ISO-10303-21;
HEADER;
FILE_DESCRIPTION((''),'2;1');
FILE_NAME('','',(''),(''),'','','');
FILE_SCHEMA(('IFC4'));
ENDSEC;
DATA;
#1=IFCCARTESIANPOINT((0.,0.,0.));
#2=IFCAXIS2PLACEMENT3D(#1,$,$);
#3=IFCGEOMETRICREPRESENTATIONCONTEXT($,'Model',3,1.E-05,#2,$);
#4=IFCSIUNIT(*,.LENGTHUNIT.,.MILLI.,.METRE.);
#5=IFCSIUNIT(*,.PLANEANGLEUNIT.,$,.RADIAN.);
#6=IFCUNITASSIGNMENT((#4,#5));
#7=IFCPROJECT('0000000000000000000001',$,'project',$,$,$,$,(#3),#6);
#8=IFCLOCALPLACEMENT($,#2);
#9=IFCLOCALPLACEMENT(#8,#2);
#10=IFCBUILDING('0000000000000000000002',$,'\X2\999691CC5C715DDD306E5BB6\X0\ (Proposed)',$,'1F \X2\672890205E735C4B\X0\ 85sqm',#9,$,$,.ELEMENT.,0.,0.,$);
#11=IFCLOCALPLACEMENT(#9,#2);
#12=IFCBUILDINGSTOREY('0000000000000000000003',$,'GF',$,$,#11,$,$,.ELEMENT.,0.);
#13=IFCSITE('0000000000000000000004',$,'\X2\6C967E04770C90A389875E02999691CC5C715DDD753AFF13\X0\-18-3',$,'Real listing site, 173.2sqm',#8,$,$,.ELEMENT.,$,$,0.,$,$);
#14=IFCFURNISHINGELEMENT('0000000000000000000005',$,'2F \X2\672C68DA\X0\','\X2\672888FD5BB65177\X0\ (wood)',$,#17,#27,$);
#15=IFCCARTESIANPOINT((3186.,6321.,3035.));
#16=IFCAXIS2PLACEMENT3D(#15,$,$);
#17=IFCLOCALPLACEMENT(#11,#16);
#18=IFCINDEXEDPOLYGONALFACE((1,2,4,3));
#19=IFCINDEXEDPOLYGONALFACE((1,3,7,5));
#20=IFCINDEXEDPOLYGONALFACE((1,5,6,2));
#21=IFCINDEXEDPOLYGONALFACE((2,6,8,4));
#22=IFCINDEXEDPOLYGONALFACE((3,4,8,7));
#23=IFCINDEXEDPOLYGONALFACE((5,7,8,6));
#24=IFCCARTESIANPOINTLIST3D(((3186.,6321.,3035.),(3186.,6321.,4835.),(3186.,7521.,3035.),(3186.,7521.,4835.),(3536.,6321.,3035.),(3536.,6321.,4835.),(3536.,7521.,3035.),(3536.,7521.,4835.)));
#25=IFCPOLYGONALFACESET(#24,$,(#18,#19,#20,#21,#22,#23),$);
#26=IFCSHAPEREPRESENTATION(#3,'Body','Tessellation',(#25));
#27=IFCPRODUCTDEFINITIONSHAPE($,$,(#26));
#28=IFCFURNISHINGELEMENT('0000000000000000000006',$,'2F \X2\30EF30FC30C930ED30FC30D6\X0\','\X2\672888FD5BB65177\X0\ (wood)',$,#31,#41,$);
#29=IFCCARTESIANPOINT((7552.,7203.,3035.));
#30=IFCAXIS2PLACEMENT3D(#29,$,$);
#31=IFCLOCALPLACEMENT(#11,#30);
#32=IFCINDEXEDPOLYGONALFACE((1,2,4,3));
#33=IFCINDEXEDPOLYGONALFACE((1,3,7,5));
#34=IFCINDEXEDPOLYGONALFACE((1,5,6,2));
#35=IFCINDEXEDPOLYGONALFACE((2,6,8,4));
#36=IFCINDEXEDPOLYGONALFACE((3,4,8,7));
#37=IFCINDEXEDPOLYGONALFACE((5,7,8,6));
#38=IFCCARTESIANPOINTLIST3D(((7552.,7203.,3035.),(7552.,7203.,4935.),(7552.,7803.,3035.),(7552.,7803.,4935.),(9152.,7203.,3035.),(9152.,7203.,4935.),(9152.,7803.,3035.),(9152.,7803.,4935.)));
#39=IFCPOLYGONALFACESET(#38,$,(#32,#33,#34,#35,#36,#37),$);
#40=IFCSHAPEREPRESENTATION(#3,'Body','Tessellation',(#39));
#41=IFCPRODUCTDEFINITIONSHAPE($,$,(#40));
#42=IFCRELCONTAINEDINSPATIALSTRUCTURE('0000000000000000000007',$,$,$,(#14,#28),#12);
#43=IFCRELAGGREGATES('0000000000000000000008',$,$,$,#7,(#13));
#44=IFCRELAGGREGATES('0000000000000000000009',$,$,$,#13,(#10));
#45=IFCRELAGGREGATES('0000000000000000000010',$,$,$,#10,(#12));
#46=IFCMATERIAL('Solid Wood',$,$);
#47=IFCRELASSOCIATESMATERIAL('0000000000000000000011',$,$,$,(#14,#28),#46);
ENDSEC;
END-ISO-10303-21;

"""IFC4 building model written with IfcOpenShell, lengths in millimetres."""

from ifc_helpers import new_model, si_unit, frame, frame_2d, origin, place, context, project, spatial, rectangle, extrude, material, element, save


model = new_model("IFC4")

# Units and contexts
model_context = context("Model", 3, precision=1e-05, world=origin())
ifc_project = project(units=[si_unit("LENGTHUNIT", "METRE", prefix="MILLI"), si_unit("PLANEANGLEUNIT", "RADIAN")], contexts=[model_context])

# Site, building, storey
site_placement = place(None, origin())
site = spatial("IfcSite", under=ifc_project, at=site_placement, Name="沖縄県那覇市首里山川町３-18-3", ObjectType="Real listing site, 173.2sqm", CompositionType="ELEMENT", RefElevation=0.0)
building_placement = place(site_placement, origin())
building = spatial("IfcBuilding", under=site, at=building_placement, Name="首里山川の家 (Proposed)", ObjectType="1F 木造平屋 85sqm", CompositionType="ELEMENT", ElevationOfRefHeight=0.0, ElevationOfTerrain=0.0)
storey_placement = place(building_placement, origin())
storey = spatial("IfcBuildingStorey", under=building, at=storey_placement, Name="GF", CompositionType="ELEMENT", Elevation=0.0)

# Shared definitions
ifc_material_1 = material(Name="Solid Wood")

# Furnishing elements
furnishing_1_placement = place(storey_placement, frame((3186.0, 6321.0, 3035.0)))
element("IfcFurnishingElement", 1, at=furnishing_1_placement, inside=storey, material=ifc_material_1, Name="2F 本棚", Description="木製家具 (wood)", context=model_context, shape_type="SweptSolid", body=[
    extrude(rectangle(XDim=350.0, YDim=1200.0, at=frame_2d((175.0, 600.0))), frame((3186.0, 6321.0, 3035.0)), (0.0, 0.0, 1.0), 1800.0),
])
furnishing_2_placement = place(storey_placement, frame((7552.0, 7203.0, 3035.0)))
element("IfcFurnishingElement", 2, at=furnishing_2_placement, inside=storey, material=ifc_material_1, Name="2F ワードローブ", Description="木製家具 (wood)", context=model_context, shape_type="SweptSolid", body=[
    extrude(rectangle(XDim=1600.0, YDim=600.0, at=frame_2d((800.0, 300.0))), frame((7552.0, 7203.0, 3035.0)), (0.0, 0.0, 1.0), 1900.0),
])

save(model, "model.ifc")
